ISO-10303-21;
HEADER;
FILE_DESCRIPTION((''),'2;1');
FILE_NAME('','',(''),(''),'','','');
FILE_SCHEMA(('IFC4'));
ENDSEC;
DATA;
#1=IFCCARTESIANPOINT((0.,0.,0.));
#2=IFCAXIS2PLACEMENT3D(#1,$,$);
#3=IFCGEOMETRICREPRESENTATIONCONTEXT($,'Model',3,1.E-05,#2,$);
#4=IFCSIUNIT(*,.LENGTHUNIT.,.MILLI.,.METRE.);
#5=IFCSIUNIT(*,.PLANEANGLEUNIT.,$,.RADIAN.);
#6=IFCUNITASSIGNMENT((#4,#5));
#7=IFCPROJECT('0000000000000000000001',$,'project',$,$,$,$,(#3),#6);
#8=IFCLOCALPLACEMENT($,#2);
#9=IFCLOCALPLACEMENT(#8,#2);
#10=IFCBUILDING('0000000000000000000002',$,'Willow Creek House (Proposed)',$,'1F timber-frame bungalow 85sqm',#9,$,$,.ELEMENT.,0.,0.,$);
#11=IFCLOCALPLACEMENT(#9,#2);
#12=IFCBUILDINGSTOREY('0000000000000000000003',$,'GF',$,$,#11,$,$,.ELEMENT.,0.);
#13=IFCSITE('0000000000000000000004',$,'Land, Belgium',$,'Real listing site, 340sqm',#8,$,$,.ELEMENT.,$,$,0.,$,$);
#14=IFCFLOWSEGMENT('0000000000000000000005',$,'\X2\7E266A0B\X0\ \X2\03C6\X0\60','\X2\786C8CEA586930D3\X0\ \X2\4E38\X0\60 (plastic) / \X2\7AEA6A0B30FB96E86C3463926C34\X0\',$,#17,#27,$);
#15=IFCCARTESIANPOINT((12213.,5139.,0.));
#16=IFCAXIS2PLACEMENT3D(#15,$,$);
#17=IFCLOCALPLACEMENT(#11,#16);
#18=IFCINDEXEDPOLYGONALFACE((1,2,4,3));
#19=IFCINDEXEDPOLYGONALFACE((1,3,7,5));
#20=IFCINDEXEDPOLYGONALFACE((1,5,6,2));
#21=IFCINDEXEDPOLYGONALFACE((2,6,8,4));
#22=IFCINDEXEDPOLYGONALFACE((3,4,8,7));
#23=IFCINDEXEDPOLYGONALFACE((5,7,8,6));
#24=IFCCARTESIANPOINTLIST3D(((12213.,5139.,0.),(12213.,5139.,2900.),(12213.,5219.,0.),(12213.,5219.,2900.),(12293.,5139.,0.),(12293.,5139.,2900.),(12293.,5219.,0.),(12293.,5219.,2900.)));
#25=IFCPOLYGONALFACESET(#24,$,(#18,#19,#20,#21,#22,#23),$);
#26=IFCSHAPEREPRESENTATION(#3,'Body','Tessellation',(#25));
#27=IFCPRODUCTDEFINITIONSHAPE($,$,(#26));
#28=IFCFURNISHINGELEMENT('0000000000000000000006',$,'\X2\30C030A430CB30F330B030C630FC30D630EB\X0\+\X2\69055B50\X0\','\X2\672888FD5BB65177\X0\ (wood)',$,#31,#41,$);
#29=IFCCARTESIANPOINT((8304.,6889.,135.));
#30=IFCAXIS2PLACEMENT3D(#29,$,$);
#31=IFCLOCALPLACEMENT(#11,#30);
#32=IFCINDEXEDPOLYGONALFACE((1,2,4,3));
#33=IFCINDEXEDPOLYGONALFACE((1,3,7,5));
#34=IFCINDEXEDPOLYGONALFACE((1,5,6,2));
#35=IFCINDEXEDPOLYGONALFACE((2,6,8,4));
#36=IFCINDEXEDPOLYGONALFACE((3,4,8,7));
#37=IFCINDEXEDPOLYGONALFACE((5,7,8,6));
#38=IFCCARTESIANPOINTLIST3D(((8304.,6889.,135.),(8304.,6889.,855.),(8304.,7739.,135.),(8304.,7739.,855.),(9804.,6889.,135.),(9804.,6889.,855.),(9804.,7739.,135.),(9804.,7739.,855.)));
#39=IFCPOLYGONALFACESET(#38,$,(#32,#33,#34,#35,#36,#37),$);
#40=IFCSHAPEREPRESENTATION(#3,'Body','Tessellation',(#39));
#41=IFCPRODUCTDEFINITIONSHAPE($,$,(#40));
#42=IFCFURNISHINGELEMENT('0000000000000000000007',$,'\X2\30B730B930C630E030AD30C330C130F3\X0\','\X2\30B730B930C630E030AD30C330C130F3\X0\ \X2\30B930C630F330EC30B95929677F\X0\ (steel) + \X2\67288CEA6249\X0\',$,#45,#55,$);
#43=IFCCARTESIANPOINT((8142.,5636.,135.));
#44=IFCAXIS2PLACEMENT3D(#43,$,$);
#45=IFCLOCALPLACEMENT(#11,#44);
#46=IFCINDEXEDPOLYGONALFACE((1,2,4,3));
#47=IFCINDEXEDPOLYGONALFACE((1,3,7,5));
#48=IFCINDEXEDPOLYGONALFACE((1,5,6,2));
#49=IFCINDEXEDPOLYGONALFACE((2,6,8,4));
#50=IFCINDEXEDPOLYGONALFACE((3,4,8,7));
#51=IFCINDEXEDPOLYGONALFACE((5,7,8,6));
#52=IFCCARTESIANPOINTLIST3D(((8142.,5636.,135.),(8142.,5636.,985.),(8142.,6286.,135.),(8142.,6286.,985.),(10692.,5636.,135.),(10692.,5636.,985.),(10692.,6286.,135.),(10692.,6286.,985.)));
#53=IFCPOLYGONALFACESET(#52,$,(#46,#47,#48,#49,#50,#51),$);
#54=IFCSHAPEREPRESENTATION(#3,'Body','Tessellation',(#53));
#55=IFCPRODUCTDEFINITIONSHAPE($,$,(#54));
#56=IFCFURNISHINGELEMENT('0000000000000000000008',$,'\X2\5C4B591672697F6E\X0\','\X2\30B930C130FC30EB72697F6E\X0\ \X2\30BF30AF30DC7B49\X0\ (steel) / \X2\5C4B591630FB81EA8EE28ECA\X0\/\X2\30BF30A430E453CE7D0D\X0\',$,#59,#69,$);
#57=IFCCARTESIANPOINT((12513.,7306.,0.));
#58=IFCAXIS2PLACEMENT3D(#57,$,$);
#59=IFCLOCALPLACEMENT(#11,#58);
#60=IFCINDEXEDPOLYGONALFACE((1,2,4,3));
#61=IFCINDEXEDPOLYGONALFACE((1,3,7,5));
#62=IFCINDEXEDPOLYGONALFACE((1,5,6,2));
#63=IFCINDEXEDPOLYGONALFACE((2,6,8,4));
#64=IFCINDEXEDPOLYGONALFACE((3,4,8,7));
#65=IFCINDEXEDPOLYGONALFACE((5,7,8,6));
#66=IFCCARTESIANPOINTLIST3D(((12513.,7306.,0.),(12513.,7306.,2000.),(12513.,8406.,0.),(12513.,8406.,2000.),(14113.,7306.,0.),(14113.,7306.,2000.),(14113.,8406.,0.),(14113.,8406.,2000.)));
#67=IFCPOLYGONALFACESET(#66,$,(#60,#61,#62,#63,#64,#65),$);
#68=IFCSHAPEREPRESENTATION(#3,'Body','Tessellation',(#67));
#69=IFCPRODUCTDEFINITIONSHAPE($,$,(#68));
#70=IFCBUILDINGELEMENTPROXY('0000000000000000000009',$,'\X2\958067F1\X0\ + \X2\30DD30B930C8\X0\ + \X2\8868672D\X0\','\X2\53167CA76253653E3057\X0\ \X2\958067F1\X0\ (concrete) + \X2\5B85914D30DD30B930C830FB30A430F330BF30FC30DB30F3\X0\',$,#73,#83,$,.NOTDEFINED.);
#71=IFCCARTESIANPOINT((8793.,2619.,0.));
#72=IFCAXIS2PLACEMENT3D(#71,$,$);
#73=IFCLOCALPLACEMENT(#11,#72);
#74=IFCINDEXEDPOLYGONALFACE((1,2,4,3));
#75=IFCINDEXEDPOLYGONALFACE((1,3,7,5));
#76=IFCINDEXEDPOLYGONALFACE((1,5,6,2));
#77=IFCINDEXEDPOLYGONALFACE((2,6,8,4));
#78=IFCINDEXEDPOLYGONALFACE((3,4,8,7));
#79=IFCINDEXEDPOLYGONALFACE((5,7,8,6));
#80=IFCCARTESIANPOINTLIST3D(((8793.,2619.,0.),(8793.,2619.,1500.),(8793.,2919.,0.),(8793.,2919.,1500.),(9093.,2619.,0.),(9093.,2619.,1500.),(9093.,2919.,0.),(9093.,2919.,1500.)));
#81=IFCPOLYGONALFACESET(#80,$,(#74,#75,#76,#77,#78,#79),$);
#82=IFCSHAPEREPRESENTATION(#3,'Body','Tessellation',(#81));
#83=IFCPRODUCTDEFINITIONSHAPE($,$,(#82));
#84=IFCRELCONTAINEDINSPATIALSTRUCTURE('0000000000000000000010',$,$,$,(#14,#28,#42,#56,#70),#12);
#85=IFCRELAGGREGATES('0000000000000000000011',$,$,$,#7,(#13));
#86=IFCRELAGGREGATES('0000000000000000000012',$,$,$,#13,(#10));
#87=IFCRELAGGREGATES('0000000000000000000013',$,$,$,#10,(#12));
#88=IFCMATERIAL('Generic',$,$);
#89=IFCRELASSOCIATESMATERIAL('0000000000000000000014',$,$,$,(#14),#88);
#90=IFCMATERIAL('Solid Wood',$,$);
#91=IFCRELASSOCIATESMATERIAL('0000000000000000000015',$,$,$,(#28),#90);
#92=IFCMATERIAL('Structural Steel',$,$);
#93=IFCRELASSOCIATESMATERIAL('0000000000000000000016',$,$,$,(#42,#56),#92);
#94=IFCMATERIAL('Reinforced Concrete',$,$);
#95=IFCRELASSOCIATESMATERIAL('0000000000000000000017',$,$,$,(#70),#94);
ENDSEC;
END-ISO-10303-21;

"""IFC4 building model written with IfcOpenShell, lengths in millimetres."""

from ifc_helpers import new_model, si_unit, frame, frame_2d, origin, place, context, project, spatial, rectangle, extrude, material, element, save


model = new_model("IFC4")

# Units and contexts
model_context = context("Model", 3, precision=1e-05, world=origin())
ifc_project = project(units=[si_unit("LENGTHUNIT", "METRE", prefix="MILLI"), si_unit("PLANEANGLEUNIT", "RADIAN")], contexts=[model_context])

# Site, building, storey
site_placement = place(None, origin())
site = spatial("IfcSite", under=ifc_project, at=site_placement, Name="Land, Belgium", ObjectType="Real listing site, 340sqm", CompositionType="ELEMENT", RefElevation=0.0)
building_placement = place(site_placement, origin())
building = spatial("IfcBuilding", under=site, at=building_placement, Name="Willow Creek House (Proposed)", ObjectType="1F timber-frame bungalow 85sqm", CompositionType="ELEMENT", ElevationOfRefHeight=0.0, ElevationOfTerrain=0.0)
storey_placement = place(building_placement, origin())
storey = spatial("IfcBuildingStorey", under=building, at=storey_placement, Name="GF", CompositionType="ELEMENT", Elevation=0.0)

# Shared definitions
ifc_material_1 = material(Name="Solid Wood")

# Shared definitions
ifc_material_2 = material(Name="Structural Steel")

# Shared definitions
ifc_material_3 = material(Name="Reinforced Concrete")

# Shared definitions
ifc_material_4 = material(Name="Generic")

# Flow segment
flow_segment_placement = place(storey_placement, frame((12213.0, 5139.0, 0.0)))
element("IfcFlowSegment", 1, at=flow_segment_placement, inside=storey, material=ifc_material_4, Name="縦樋 φ60", Description="硬質塩ビ 丸60 (plastic) / 竪樋・雨水排水", context=model_context, shape_type="SweptSolid", body=[
    extrude(rectangle(XDim=80.0, YDim=80.0, at=frame_2d((40.0, 40.0))), frame((12213.0, 5139.0, 0.0)), (0.0, 0.0, 1.0), 2900.0),
])

# Furnishing elements
furnishing_1_placement = place(storey_placement, frame((8304.0, 6889.0, 135.0)))
element("IfcFurnishingElement", 2, at=furnishing_1_placement, inside=storey, material=ifc_material_1, Name="ダイニングテーブル+椅子", Description="木製家具 (wood)", context=model_context, shape_type="SweptSolid", body=[
    extrude(rectangle(XDim=1500.0, YDim=850.0, at=frame_2d((750.0, 425.0))), frame((8304.0, 6889.0, 135.0)), (0.0, 0.0, 1.0), 720.0),
])
furnishing_2_placement = place(storey_placement, frame((8142.0, 5636.0, 135.0)))
element("IfcFurnishingElement", 3, at=furnishing_2_placement, inside=storey, material=ifc_material_2, Name="システムキッチン", Description="システムキッチン ステンレス天板 (steel) + 木質扉", context=model_context, shape_type="SweptSolid", body=[
    extrude(rectangle(XDim=2550.0, YDim=650.0, at=frame_2d((1275.0, 325.0))), frame((8142.0, 5636.0, 135.0)), (0.0, 0.0, 1.0), 850.0),
])
furnishing_3_placement = place(storey_placement, frame((12513.0, 7306.0, 0.0)))
element("IfcFurnishingElement", 4, at=furnishing_3_placement, inside=storey, material=ifc_material_2, Name="屋外物置", Description="スチール物置 タクボ等 (steel) / 屋外・自転車/タイヤ収納", context=model_context, shape_type="SweptSolid", body=[
    extrude(rectangle(XDim=1600.0, YDim=1100.0, at=frame_2d((800.0, 550.0))), frame((12513.0, 7306.0, 0.0)), (0.0, 0.0, 1.0), 2000.0),
])

# Building element proxy
proxy_placement = place(storey_placement, frame((8793.0, 2619.0, 0.0)))
element("IfcBuildingElementProxy", 5, at=proxy_placement, inside=storey, material=ifc_material_3, Name="門柱 + ポスト + 表札", Description="化粧打放し 門柱 (concrete) + 宅配ポスト・インターホン", PredefinedType="NOTDEFINED", context=model_context, shape_type="SweptSolid", body=[
    extrude(rectangle(XDim=300.0, YDim=300.0, at=frame_2d((150.0, 150.0))), frame((8793.0, 2619.0, 0.0)), (0.0, 0.0, 1.0), 1500.0),
])

save(model, "model.ifc")
